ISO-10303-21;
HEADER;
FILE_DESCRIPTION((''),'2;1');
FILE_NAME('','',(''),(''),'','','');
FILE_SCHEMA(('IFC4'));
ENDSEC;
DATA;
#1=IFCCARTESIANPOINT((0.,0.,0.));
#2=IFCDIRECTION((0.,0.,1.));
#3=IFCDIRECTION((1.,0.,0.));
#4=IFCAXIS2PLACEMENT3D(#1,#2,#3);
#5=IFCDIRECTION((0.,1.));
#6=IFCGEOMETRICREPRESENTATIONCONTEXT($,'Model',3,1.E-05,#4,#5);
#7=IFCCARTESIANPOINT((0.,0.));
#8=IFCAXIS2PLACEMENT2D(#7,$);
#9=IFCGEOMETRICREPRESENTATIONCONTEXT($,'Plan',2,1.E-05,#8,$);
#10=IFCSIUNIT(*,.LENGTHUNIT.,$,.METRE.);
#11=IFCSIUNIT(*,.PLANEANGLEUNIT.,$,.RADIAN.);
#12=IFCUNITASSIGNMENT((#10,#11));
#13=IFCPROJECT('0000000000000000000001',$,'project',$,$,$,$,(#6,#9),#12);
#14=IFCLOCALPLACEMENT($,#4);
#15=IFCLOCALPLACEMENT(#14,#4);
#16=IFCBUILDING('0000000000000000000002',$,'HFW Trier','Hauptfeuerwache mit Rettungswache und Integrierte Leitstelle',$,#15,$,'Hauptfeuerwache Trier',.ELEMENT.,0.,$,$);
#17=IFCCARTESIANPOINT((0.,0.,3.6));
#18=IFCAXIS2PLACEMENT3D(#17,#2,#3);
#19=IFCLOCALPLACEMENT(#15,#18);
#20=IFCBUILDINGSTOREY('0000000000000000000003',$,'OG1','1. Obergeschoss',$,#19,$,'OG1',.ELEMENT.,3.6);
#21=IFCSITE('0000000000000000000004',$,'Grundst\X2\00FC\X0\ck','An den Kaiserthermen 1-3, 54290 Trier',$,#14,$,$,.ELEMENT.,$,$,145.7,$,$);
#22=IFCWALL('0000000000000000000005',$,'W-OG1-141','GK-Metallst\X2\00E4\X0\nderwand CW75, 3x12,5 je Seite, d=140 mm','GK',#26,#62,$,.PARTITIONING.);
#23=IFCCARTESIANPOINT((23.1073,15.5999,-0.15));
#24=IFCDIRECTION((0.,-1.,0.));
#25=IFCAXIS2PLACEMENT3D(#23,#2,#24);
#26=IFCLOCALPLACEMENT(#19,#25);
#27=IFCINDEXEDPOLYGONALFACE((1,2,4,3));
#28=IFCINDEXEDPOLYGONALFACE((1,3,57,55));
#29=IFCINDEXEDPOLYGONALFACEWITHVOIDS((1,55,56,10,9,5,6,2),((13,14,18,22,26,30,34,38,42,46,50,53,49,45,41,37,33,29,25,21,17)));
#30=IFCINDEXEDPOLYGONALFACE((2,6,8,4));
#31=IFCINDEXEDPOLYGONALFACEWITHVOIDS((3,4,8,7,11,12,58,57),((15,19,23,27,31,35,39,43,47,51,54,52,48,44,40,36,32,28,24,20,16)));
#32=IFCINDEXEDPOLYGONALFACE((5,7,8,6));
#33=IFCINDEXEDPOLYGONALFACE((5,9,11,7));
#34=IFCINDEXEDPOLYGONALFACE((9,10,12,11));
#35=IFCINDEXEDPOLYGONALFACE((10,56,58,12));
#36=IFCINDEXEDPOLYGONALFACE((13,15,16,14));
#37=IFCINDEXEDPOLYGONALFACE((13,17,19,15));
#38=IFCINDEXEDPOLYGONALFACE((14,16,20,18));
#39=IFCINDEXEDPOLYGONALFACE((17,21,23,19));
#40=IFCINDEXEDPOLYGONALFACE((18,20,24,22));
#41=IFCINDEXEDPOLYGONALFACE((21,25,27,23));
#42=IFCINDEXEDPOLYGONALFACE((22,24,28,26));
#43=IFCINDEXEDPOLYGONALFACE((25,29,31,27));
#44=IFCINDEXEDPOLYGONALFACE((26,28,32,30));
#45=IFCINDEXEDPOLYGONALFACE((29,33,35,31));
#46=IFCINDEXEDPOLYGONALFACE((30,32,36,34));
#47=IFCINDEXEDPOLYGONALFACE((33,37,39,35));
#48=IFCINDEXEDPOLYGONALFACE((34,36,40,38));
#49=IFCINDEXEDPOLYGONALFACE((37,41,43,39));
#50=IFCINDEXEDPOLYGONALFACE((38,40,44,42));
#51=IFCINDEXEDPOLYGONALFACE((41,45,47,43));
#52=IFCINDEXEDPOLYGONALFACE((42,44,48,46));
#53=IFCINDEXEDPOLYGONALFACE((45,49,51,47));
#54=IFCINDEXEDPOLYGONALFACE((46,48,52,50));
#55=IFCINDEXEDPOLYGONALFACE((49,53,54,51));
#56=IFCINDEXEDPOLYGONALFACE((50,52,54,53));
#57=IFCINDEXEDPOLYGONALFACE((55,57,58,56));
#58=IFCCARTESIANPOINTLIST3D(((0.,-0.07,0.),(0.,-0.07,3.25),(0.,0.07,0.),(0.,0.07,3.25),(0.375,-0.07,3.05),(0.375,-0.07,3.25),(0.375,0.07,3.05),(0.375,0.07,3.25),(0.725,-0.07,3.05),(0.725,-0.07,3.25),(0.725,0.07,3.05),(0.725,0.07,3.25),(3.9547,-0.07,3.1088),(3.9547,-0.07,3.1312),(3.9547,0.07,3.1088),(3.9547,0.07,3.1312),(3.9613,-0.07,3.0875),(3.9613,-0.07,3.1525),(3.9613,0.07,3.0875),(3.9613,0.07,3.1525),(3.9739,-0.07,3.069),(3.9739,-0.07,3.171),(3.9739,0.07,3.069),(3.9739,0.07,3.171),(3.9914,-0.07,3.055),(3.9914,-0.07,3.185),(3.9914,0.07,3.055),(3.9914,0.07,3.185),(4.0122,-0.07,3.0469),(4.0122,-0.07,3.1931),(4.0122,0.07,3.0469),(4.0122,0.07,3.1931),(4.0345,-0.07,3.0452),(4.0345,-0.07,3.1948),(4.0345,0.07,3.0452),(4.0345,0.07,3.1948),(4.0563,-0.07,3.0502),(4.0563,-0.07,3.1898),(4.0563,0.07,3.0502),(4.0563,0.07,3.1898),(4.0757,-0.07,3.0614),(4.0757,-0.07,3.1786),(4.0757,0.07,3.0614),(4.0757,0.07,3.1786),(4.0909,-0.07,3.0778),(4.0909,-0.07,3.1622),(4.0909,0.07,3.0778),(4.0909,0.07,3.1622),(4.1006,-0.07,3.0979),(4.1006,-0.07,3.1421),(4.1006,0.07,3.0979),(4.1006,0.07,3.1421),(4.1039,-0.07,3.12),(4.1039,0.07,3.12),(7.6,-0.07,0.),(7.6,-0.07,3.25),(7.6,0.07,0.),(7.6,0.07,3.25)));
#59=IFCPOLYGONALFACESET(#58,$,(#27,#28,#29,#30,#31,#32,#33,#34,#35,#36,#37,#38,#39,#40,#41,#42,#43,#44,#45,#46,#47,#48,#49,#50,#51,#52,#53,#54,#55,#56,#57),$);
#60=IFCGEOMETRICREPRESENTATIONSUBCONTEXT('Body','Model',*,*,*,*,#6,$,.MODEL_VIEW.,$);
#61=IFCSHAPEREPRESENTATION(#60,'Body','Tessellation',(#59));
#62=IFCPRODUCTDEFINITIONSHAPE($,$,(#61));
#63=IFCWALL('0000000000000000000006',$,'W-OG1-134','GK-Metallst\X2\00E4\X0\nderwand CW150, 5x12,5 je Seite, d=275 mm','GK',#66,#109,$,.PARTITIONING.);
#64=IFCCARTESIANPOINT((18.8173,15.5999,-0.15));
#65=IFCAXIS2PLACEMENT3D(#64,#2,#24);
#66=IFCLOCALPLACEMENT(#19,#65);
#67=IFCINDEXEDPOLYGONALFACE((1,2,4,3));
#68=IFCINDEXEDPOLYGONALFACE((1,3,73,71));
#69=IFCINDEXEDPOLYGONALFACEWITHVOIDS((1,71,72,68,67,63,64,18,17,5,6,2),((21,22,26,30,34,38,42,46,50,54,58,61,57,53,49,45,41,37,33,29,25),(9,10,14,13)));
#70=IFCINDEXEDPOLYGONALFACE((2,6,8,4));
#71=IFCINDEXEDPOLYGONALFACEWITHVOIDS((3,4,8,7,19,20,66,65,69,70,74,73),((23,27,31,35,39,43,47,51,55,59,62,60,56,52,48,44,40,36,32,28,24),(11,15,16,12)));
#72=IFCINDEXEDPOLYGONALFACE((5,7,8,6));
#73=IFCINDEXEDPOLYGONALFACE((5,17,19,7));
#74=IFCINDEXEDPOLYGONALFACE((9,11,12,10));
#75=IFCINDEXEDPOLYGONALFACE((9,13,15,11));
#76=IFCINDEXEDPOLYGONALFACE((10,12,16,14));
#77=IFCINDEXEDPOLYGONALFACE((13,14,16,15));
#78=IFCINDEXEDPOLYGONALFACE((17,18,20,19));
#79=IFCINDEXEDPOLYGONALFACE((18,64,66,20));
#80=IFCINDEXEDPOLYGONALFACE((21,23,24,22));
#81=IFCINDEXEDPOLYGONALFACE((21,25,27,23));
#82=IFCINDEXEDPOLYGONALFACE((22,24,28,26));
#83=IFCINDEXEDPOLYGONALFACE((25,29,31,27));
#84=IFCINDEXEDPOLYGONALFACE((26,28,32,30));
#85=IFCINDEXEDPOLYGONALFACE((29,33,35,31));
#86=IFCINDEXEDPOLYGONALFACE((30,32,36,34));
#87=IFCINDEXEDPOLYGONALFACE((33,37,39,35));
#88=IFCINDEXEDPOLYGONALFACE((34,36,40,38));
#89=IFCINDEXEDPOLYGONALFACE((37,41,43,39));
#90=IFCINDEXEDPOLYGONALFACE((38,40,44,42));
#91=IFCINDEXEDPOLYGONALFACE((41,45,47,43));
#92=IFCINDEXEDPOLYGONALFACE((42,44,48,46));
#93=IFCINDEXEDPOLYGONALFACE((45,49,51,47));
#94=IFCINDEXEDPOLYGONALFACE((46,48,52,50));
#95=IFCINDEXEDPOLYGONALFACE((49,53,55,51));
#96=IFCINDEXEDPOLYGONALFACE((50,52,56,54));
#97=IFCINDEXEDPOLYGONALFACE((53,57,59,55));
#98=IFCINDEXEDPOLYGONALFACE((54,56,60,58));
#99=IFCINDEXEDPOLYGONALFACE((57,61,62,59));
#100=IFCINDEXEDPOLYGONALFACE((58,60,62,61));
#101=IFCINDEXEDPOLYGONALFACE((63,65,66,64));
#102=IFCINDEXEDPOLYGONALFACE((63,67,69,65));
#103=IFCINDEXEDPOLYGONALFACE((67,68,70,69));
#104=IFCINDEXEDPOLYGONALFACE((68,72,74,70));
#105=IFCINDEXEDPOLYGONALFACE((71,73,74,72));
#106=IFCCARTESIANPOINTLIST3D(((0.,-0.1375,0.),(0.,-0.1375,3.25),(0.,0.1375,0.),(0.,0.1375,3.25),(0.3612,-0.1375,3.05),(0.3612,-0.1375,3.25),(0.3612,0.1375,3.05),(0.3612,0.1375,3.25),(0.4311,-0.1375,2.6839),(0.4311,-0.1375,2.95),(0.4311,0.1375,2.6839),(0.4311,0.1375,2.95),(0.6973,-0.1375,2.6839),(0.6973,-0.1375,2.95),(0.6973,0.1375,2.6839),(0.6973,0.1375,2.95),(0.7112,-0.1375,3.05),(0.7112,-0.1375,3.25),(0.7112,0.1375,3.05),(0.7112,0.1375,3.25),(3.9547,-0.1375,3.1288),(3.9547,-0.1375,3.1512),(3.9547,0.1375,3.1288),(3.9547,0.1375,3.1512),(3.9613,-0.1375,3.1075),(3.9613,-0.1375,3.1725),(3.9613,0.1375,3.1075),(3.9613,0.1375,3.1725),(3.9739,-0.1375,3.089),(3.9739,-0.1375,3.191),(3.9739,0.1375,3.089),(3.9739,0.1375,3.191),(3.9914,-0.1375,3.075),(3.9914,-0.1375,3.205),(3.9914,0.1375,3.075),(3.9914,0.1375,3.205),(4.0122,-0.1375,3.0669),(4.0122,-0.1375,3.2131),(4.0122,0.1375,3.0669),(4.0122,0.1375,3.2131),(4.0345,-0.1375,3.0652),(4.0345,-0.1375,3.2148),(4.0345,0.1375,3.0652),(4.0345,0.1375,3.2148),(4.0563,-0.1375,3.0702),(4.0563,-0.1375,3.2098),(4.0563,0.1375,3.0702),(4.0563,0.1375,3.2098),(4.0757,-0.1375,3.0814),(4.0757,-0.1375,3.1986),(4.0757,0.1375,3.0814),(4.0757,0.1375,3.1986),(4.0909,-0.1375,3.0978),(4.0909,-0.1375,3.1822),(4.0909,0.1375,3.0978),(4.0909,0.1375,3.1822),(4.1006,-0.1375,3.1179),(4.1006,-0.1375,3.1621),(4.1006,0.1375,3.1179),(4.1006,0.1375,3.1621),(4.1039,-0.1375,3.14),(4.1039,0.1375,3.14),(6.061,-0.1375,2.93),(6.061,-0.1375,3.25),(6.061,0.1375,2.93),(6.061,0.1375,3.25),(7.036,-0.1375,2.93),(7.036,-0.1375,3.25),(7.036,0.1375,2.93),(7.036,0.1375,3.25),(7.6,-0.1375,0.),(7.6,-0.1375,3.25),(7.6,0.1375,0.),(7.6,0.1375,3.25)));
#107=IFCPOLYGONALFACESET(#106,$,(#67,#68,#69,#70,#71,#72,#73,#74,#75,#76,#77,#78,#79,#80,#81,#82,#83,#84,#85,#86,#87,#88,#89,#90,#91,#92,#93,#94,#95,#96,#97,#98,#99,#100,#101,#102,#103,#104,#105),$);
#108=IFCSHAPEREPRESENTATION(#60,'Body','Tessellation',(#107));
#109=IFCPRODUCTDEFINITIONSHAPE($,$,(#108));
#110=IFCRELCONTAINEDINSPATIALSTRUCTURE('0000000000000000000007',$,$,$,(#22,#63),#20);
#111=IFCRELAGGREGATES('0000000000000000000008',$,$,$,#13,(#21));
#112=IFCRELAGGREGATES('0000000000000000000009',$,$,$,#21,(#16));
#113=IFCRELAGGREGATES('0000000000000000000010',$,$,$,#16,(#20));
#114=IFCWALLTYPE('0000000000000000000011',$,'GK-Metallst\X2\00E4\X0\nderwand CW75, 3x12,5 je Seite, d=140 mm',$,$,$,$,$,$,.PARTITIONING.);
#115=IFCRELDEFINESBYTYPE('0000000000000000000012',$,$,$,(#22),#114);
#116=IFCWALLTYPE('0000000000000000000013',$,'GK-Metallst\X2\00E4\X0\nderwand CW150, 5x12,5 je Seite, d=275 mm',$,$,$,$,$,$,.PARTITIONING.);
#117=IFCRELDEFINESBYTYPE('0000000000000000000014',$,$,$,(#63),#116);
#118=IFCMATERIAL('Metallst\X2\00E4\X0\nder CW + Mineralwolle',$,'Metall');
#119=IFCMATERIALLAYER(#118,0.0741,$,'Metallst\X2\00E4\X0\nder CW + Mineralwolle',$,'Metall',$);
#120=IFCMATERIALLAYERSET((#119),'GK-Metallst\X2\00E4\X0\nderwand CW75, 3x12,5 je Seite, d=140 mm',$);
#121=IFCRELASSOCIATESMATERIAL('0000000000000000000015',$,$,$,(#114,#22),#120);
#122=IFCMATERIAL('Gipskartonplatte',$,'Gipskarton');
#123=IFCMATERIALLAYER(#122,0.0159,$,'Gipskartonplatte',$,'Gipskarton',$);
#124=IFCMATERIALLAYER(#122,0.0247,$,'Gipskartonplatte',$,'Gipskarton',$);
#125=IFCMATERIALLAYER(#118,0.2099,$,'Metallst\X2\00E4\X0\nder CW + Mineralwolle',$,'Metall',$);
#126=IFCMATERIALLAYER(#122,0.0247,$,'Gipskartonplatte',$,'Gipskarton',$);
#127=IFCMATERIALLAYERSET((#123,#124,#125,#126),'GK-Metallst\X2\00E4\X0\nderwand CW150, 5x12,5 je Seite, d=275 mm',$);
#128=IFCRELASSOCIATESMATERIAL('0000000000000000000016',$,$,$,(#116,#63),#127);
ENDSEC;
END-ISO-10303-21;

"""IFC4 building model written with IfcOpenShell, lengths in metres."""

from ifc_helpers import new_model, si_unit, direction, frame, frame_2d, origin_with_axes, origin_2d, place, context, subcontext, project, spatial, rectangle, circle, extrude, material, layer, layer_set, layer_usage, type_object, element, save


model = new_model("IFC4")

# Units and contexts
model_context = context("Model", 3, precision=1e-05, world=origin_with_axes(), true_north=direction((0.0, 1.0)))
plan_context = context("Plan", 2, precision=1e-05, world=origin_2d())
body_context = subcontext(model_context, "Body", "Model", "MODEL_VIEW")
ifc_project = project(units=[si_unit("LENGTHUNIT", "METRE"), si_unit("PLANEANGLEUNIT", "RADIAN")], contexts=[model_context, plan_context])

# Site, building, storey
site_placement = place(None, origin_with_axes())
site = spatial("IfcSite", under=ifc_project, at=site_placement, Name="Grundstück", Description="An den Kaiserthermen 1-3, 54290 Trier", CompositionType="ELEMENT", RefElevation=145.7)
building_placement = place(site_placement, origin_with_axes())
building = spatial("IfcBuilding", under=site, at=building_placement, Name="HFW Trier", Description="Hauptfeuerwache mit Rettungswache und Integrierte Leitstelle", LongName="Hauptfeuerwache Trier", CompositionType="ELEMENT", ElevationOfRefHeight=0.0)
storey_placement = place(building_placement, frame((0.0, 0.0, 3.6), z_axis=(0.0, 0.0, 1.0), x_axis=(1.0, 0.0, 0.0)))
storey = spatial("IfcBuildingStorey", under=building, at=storey_placement, Name="OG1", Description="1. Obergeschoss", LongName="OG1", CompositionType="ELEMENT", Elevation=3.6)

# Shared definitions
ifc_material_1 = material(Name="Metallständer CW + Mineralwolle", Category="Metall")
ifc_layer_1 = layer(ifc_material_1, 0.0741, Name="Metallständer CW + Mineralwolle", Category="Metall")
ifc_layer_set_1 = layer_set([ifc_layer_1], Name="GK-Metallständerwand CW75, 3x12,5 je Seite, d=140 mm")
wall_type_1 = type_object("IfcWallType", Name="GK-Metallständerwand CW75, 3x12,5 je Seite, d=140 mm", PredefinedType="PARTITIONING", material=ifc_layer_set_1)

# Wall, openings
ifc_layer_usage_1 = layer_usage(ifc_layer_set_1, "AXIS2", "POSITIVE", -0.07)
wall_1_placement = place(storey_placement, frame((23.1073, 15.5999, -0.15), z_axis=(0.0, 0.0, 1.0), x_axis=(0.0, -1.0, 0.0)))
wall_1 = element("IfcWall", 1, at=wall_1_placement, inside=storey, type_object=wall_type_1, material=ifc_layer_usage_1, Name="W-OG1-141", Description="GK-Metallständerwand CW75, 3x12,5 je Seite, d=140 mm", ObjectType="GK", PredefinedType="PARTITIONING", context=body_context, shape_type="SweptSolid", body=[
    extrude(rectangle(XDim=7.6, YDim=0.14, at=frame_2d((3.8, 0.0))), origin_with_axes(), (0.0, 0.0, 1.0), 3.25),
])
opening_1_placement = place(wall_1_placement, origin_with_axes())
element("IfcOpeningElement", 2, at=opening_1_placement, cuts=wall_1, ObjectType="Wanddurchbruch", PredefinedType="OPENING", context=body_context, shape_type="SweptSolid", body=[
    extrude(circle(Radius=0.075, at=origin_2d()), frame((4.0289, -0.12, 3.12), z_axis=(0.0, 1.0, 0.0), x_axis=(1.0, 0.0, 0.0)), (0.0, 0.0, 1.0), 0.24),
])
opening_2_placement = place(wall_1_placement, origin_with_axes())
element("IfcOpeningElement", 3, at=opening_2_placement, cuts=wall_1, ObjectType="Wanddurchbruch", PredefinedType="OPENING", context=body_context, shape_type="SweptSolid", body=[
    extrude(rectangle(XDim=0.35, YDim=0.24, at=frame_2d((0.55, 0.0))), frame((0.0, 0.0, 3.05), z_axis=(0.0, 0.0, 1.0), x_axis=(1.0, 0.0, 0.0)), (0.0, 0.0, 1.0), 0.2),
])

# Shared definitions
ifc_material_2 = material(Name="Gipskartonplatte", Category="Gipskarton")

# Wall, openings
ifc_layer_2 = layer(ifc_material_2, 0.0159, Name="Gipskartonplatte", Category="Gipskarton")
ifc_layer_3 = layer(ifc_material_2, 0.0247, Name="Gipskartonplatte", Category="Gipskarton")
ifc_layer_4 = layer(ifc_material_1, 0.2099, Name="Metallständer CW + Mineralwolle", Category="Metall")
ifc_layer_5 = layer(ifc_material_2, 0.0247, Name="Gipskartonplatte", Category="Gipskarton")
ifc_layer_set_2 = layer_set([ifc_layer_2, ifc_layer_3, ifc_layer_4, ifc_layer_5], Name="GK-Metallständerwand CW150, 5x12,5 je Seite, d=275 mm")
ifc_layer_usage_2 = layer_usage(ifc_layer_set_2, "AXIS2", "POSITIVE", -0.1375)
wall_type_2 = type_object("IfcWallType", Name="GK-Metallständerwand CW150, 5x12,5 je Seite, d=275 mm", PredefinedType="PARTITIONING", material=ifc_layer_set_2)
wall_2_placement = place(storey_placement, frame((18.8173, 15.5999, -0.15), z_axis=(0.0, 0.0, 1.0), x_axis=(0.0, -1.0, 0.0)))
wall_2 = element("IfcWall", 4, at=wall_2_placement, inside=storey, type_object=wall_type_2, material=ifc_layer_usage_2, Name="W-OG1-134", Description="GK-Metallständerwand CW150, 5x12,5 je Seite, d=275 mm", ObjectType="GK", PredefinedType="PARTITIONING", context=body_context, shape_type="SweptSolid", body=[
    extrude(rectangle(XDim=7.6, YDim=0.275, at=frame_2d((3.8, 0.0))), origin_with_axes(), (0.0, 0.0, 1.0), 3.25),
])
opening_3_placement = place(wall_2_placement, origin_with_axes())
element("IfcOpeningElement", 5, at=opening_3_placement, cuts=wall_2, ObjectType="Wanddurchbruch", PredefinedType="OPENING", context=body_context, shape_type="SweptSolid", body=[
    extrude(rectangle(XDim=0.975, YDim=0.375, at=frame_2d((6.5485, 0.0))), frame((0.0, 0.0, 2.93), z_axis=(0.0, 0.0, 1.0), x_axis=(1.0, 0.0, 0.0)), (0.0, 0.0, 1.0), 0.32),
])
opening_4_placement = place(wall_2_placement, origin_with_axes())
element("IfcOpeningElement", 6, at=opening_4_placement, cuts=wall_2, ObjectType="Wanddurchbruch", PredefinedType="OPENING", context=body_context, shape_type="SweptSolid", body=[
    extrude(circle(Radius=0.075, at=origin_2d()), frame((4.0289, -0.1875, 3.14), z_axis=(0.0, 1.0, 0.0), x_axis=(1.0, 0.0, 0.0)), (0.0, 0.0, 1.0), 0.375),
])
opening_5_placement = place(wall_2_placement, origin_with_axes())
element("IfcOpeningElement", 7, at=opening_5_placement, cuts=wall_2, ObjectType="Wanddurchbruch", PredefinedType="OPENING", context=body_context, shape_type="SweptSolid", body=[
    extrude(rectangle(XDim=0.35, YDim=0.375, at=frame_2d((0.5362, 0.0))), frame((0.0, 0.0, 3.05), z_axis=(0.0, 0.0, 1.0), x_axis=(1.0, 0.0, 0.0)), (0.0, 0.0, 1.0), 0.2),
])
opening_6_placement = place(wall_2_placement, origin_with_axes())
element("IfcOpeningElement", 8, at=opening_6_placement, cuts=wall_2, ObjectType="Wanddurchbruch", PredefinedType="OPENING", context=body_context, shape_type="SweptSolid", body=[
    extrude(rectangle(XDim=0.2661, YDim=0.375, at=frame_2d((0.5642, 0.0))), frame((0.0, 0.0, 2.6839), z_axis=(0.0, 0.0, 1.0), x_axis=(1.0, 0.0, 0.0)), (0.0, 0.0, 1.0), 0.2661),
])

save(model, "model.ifc")
